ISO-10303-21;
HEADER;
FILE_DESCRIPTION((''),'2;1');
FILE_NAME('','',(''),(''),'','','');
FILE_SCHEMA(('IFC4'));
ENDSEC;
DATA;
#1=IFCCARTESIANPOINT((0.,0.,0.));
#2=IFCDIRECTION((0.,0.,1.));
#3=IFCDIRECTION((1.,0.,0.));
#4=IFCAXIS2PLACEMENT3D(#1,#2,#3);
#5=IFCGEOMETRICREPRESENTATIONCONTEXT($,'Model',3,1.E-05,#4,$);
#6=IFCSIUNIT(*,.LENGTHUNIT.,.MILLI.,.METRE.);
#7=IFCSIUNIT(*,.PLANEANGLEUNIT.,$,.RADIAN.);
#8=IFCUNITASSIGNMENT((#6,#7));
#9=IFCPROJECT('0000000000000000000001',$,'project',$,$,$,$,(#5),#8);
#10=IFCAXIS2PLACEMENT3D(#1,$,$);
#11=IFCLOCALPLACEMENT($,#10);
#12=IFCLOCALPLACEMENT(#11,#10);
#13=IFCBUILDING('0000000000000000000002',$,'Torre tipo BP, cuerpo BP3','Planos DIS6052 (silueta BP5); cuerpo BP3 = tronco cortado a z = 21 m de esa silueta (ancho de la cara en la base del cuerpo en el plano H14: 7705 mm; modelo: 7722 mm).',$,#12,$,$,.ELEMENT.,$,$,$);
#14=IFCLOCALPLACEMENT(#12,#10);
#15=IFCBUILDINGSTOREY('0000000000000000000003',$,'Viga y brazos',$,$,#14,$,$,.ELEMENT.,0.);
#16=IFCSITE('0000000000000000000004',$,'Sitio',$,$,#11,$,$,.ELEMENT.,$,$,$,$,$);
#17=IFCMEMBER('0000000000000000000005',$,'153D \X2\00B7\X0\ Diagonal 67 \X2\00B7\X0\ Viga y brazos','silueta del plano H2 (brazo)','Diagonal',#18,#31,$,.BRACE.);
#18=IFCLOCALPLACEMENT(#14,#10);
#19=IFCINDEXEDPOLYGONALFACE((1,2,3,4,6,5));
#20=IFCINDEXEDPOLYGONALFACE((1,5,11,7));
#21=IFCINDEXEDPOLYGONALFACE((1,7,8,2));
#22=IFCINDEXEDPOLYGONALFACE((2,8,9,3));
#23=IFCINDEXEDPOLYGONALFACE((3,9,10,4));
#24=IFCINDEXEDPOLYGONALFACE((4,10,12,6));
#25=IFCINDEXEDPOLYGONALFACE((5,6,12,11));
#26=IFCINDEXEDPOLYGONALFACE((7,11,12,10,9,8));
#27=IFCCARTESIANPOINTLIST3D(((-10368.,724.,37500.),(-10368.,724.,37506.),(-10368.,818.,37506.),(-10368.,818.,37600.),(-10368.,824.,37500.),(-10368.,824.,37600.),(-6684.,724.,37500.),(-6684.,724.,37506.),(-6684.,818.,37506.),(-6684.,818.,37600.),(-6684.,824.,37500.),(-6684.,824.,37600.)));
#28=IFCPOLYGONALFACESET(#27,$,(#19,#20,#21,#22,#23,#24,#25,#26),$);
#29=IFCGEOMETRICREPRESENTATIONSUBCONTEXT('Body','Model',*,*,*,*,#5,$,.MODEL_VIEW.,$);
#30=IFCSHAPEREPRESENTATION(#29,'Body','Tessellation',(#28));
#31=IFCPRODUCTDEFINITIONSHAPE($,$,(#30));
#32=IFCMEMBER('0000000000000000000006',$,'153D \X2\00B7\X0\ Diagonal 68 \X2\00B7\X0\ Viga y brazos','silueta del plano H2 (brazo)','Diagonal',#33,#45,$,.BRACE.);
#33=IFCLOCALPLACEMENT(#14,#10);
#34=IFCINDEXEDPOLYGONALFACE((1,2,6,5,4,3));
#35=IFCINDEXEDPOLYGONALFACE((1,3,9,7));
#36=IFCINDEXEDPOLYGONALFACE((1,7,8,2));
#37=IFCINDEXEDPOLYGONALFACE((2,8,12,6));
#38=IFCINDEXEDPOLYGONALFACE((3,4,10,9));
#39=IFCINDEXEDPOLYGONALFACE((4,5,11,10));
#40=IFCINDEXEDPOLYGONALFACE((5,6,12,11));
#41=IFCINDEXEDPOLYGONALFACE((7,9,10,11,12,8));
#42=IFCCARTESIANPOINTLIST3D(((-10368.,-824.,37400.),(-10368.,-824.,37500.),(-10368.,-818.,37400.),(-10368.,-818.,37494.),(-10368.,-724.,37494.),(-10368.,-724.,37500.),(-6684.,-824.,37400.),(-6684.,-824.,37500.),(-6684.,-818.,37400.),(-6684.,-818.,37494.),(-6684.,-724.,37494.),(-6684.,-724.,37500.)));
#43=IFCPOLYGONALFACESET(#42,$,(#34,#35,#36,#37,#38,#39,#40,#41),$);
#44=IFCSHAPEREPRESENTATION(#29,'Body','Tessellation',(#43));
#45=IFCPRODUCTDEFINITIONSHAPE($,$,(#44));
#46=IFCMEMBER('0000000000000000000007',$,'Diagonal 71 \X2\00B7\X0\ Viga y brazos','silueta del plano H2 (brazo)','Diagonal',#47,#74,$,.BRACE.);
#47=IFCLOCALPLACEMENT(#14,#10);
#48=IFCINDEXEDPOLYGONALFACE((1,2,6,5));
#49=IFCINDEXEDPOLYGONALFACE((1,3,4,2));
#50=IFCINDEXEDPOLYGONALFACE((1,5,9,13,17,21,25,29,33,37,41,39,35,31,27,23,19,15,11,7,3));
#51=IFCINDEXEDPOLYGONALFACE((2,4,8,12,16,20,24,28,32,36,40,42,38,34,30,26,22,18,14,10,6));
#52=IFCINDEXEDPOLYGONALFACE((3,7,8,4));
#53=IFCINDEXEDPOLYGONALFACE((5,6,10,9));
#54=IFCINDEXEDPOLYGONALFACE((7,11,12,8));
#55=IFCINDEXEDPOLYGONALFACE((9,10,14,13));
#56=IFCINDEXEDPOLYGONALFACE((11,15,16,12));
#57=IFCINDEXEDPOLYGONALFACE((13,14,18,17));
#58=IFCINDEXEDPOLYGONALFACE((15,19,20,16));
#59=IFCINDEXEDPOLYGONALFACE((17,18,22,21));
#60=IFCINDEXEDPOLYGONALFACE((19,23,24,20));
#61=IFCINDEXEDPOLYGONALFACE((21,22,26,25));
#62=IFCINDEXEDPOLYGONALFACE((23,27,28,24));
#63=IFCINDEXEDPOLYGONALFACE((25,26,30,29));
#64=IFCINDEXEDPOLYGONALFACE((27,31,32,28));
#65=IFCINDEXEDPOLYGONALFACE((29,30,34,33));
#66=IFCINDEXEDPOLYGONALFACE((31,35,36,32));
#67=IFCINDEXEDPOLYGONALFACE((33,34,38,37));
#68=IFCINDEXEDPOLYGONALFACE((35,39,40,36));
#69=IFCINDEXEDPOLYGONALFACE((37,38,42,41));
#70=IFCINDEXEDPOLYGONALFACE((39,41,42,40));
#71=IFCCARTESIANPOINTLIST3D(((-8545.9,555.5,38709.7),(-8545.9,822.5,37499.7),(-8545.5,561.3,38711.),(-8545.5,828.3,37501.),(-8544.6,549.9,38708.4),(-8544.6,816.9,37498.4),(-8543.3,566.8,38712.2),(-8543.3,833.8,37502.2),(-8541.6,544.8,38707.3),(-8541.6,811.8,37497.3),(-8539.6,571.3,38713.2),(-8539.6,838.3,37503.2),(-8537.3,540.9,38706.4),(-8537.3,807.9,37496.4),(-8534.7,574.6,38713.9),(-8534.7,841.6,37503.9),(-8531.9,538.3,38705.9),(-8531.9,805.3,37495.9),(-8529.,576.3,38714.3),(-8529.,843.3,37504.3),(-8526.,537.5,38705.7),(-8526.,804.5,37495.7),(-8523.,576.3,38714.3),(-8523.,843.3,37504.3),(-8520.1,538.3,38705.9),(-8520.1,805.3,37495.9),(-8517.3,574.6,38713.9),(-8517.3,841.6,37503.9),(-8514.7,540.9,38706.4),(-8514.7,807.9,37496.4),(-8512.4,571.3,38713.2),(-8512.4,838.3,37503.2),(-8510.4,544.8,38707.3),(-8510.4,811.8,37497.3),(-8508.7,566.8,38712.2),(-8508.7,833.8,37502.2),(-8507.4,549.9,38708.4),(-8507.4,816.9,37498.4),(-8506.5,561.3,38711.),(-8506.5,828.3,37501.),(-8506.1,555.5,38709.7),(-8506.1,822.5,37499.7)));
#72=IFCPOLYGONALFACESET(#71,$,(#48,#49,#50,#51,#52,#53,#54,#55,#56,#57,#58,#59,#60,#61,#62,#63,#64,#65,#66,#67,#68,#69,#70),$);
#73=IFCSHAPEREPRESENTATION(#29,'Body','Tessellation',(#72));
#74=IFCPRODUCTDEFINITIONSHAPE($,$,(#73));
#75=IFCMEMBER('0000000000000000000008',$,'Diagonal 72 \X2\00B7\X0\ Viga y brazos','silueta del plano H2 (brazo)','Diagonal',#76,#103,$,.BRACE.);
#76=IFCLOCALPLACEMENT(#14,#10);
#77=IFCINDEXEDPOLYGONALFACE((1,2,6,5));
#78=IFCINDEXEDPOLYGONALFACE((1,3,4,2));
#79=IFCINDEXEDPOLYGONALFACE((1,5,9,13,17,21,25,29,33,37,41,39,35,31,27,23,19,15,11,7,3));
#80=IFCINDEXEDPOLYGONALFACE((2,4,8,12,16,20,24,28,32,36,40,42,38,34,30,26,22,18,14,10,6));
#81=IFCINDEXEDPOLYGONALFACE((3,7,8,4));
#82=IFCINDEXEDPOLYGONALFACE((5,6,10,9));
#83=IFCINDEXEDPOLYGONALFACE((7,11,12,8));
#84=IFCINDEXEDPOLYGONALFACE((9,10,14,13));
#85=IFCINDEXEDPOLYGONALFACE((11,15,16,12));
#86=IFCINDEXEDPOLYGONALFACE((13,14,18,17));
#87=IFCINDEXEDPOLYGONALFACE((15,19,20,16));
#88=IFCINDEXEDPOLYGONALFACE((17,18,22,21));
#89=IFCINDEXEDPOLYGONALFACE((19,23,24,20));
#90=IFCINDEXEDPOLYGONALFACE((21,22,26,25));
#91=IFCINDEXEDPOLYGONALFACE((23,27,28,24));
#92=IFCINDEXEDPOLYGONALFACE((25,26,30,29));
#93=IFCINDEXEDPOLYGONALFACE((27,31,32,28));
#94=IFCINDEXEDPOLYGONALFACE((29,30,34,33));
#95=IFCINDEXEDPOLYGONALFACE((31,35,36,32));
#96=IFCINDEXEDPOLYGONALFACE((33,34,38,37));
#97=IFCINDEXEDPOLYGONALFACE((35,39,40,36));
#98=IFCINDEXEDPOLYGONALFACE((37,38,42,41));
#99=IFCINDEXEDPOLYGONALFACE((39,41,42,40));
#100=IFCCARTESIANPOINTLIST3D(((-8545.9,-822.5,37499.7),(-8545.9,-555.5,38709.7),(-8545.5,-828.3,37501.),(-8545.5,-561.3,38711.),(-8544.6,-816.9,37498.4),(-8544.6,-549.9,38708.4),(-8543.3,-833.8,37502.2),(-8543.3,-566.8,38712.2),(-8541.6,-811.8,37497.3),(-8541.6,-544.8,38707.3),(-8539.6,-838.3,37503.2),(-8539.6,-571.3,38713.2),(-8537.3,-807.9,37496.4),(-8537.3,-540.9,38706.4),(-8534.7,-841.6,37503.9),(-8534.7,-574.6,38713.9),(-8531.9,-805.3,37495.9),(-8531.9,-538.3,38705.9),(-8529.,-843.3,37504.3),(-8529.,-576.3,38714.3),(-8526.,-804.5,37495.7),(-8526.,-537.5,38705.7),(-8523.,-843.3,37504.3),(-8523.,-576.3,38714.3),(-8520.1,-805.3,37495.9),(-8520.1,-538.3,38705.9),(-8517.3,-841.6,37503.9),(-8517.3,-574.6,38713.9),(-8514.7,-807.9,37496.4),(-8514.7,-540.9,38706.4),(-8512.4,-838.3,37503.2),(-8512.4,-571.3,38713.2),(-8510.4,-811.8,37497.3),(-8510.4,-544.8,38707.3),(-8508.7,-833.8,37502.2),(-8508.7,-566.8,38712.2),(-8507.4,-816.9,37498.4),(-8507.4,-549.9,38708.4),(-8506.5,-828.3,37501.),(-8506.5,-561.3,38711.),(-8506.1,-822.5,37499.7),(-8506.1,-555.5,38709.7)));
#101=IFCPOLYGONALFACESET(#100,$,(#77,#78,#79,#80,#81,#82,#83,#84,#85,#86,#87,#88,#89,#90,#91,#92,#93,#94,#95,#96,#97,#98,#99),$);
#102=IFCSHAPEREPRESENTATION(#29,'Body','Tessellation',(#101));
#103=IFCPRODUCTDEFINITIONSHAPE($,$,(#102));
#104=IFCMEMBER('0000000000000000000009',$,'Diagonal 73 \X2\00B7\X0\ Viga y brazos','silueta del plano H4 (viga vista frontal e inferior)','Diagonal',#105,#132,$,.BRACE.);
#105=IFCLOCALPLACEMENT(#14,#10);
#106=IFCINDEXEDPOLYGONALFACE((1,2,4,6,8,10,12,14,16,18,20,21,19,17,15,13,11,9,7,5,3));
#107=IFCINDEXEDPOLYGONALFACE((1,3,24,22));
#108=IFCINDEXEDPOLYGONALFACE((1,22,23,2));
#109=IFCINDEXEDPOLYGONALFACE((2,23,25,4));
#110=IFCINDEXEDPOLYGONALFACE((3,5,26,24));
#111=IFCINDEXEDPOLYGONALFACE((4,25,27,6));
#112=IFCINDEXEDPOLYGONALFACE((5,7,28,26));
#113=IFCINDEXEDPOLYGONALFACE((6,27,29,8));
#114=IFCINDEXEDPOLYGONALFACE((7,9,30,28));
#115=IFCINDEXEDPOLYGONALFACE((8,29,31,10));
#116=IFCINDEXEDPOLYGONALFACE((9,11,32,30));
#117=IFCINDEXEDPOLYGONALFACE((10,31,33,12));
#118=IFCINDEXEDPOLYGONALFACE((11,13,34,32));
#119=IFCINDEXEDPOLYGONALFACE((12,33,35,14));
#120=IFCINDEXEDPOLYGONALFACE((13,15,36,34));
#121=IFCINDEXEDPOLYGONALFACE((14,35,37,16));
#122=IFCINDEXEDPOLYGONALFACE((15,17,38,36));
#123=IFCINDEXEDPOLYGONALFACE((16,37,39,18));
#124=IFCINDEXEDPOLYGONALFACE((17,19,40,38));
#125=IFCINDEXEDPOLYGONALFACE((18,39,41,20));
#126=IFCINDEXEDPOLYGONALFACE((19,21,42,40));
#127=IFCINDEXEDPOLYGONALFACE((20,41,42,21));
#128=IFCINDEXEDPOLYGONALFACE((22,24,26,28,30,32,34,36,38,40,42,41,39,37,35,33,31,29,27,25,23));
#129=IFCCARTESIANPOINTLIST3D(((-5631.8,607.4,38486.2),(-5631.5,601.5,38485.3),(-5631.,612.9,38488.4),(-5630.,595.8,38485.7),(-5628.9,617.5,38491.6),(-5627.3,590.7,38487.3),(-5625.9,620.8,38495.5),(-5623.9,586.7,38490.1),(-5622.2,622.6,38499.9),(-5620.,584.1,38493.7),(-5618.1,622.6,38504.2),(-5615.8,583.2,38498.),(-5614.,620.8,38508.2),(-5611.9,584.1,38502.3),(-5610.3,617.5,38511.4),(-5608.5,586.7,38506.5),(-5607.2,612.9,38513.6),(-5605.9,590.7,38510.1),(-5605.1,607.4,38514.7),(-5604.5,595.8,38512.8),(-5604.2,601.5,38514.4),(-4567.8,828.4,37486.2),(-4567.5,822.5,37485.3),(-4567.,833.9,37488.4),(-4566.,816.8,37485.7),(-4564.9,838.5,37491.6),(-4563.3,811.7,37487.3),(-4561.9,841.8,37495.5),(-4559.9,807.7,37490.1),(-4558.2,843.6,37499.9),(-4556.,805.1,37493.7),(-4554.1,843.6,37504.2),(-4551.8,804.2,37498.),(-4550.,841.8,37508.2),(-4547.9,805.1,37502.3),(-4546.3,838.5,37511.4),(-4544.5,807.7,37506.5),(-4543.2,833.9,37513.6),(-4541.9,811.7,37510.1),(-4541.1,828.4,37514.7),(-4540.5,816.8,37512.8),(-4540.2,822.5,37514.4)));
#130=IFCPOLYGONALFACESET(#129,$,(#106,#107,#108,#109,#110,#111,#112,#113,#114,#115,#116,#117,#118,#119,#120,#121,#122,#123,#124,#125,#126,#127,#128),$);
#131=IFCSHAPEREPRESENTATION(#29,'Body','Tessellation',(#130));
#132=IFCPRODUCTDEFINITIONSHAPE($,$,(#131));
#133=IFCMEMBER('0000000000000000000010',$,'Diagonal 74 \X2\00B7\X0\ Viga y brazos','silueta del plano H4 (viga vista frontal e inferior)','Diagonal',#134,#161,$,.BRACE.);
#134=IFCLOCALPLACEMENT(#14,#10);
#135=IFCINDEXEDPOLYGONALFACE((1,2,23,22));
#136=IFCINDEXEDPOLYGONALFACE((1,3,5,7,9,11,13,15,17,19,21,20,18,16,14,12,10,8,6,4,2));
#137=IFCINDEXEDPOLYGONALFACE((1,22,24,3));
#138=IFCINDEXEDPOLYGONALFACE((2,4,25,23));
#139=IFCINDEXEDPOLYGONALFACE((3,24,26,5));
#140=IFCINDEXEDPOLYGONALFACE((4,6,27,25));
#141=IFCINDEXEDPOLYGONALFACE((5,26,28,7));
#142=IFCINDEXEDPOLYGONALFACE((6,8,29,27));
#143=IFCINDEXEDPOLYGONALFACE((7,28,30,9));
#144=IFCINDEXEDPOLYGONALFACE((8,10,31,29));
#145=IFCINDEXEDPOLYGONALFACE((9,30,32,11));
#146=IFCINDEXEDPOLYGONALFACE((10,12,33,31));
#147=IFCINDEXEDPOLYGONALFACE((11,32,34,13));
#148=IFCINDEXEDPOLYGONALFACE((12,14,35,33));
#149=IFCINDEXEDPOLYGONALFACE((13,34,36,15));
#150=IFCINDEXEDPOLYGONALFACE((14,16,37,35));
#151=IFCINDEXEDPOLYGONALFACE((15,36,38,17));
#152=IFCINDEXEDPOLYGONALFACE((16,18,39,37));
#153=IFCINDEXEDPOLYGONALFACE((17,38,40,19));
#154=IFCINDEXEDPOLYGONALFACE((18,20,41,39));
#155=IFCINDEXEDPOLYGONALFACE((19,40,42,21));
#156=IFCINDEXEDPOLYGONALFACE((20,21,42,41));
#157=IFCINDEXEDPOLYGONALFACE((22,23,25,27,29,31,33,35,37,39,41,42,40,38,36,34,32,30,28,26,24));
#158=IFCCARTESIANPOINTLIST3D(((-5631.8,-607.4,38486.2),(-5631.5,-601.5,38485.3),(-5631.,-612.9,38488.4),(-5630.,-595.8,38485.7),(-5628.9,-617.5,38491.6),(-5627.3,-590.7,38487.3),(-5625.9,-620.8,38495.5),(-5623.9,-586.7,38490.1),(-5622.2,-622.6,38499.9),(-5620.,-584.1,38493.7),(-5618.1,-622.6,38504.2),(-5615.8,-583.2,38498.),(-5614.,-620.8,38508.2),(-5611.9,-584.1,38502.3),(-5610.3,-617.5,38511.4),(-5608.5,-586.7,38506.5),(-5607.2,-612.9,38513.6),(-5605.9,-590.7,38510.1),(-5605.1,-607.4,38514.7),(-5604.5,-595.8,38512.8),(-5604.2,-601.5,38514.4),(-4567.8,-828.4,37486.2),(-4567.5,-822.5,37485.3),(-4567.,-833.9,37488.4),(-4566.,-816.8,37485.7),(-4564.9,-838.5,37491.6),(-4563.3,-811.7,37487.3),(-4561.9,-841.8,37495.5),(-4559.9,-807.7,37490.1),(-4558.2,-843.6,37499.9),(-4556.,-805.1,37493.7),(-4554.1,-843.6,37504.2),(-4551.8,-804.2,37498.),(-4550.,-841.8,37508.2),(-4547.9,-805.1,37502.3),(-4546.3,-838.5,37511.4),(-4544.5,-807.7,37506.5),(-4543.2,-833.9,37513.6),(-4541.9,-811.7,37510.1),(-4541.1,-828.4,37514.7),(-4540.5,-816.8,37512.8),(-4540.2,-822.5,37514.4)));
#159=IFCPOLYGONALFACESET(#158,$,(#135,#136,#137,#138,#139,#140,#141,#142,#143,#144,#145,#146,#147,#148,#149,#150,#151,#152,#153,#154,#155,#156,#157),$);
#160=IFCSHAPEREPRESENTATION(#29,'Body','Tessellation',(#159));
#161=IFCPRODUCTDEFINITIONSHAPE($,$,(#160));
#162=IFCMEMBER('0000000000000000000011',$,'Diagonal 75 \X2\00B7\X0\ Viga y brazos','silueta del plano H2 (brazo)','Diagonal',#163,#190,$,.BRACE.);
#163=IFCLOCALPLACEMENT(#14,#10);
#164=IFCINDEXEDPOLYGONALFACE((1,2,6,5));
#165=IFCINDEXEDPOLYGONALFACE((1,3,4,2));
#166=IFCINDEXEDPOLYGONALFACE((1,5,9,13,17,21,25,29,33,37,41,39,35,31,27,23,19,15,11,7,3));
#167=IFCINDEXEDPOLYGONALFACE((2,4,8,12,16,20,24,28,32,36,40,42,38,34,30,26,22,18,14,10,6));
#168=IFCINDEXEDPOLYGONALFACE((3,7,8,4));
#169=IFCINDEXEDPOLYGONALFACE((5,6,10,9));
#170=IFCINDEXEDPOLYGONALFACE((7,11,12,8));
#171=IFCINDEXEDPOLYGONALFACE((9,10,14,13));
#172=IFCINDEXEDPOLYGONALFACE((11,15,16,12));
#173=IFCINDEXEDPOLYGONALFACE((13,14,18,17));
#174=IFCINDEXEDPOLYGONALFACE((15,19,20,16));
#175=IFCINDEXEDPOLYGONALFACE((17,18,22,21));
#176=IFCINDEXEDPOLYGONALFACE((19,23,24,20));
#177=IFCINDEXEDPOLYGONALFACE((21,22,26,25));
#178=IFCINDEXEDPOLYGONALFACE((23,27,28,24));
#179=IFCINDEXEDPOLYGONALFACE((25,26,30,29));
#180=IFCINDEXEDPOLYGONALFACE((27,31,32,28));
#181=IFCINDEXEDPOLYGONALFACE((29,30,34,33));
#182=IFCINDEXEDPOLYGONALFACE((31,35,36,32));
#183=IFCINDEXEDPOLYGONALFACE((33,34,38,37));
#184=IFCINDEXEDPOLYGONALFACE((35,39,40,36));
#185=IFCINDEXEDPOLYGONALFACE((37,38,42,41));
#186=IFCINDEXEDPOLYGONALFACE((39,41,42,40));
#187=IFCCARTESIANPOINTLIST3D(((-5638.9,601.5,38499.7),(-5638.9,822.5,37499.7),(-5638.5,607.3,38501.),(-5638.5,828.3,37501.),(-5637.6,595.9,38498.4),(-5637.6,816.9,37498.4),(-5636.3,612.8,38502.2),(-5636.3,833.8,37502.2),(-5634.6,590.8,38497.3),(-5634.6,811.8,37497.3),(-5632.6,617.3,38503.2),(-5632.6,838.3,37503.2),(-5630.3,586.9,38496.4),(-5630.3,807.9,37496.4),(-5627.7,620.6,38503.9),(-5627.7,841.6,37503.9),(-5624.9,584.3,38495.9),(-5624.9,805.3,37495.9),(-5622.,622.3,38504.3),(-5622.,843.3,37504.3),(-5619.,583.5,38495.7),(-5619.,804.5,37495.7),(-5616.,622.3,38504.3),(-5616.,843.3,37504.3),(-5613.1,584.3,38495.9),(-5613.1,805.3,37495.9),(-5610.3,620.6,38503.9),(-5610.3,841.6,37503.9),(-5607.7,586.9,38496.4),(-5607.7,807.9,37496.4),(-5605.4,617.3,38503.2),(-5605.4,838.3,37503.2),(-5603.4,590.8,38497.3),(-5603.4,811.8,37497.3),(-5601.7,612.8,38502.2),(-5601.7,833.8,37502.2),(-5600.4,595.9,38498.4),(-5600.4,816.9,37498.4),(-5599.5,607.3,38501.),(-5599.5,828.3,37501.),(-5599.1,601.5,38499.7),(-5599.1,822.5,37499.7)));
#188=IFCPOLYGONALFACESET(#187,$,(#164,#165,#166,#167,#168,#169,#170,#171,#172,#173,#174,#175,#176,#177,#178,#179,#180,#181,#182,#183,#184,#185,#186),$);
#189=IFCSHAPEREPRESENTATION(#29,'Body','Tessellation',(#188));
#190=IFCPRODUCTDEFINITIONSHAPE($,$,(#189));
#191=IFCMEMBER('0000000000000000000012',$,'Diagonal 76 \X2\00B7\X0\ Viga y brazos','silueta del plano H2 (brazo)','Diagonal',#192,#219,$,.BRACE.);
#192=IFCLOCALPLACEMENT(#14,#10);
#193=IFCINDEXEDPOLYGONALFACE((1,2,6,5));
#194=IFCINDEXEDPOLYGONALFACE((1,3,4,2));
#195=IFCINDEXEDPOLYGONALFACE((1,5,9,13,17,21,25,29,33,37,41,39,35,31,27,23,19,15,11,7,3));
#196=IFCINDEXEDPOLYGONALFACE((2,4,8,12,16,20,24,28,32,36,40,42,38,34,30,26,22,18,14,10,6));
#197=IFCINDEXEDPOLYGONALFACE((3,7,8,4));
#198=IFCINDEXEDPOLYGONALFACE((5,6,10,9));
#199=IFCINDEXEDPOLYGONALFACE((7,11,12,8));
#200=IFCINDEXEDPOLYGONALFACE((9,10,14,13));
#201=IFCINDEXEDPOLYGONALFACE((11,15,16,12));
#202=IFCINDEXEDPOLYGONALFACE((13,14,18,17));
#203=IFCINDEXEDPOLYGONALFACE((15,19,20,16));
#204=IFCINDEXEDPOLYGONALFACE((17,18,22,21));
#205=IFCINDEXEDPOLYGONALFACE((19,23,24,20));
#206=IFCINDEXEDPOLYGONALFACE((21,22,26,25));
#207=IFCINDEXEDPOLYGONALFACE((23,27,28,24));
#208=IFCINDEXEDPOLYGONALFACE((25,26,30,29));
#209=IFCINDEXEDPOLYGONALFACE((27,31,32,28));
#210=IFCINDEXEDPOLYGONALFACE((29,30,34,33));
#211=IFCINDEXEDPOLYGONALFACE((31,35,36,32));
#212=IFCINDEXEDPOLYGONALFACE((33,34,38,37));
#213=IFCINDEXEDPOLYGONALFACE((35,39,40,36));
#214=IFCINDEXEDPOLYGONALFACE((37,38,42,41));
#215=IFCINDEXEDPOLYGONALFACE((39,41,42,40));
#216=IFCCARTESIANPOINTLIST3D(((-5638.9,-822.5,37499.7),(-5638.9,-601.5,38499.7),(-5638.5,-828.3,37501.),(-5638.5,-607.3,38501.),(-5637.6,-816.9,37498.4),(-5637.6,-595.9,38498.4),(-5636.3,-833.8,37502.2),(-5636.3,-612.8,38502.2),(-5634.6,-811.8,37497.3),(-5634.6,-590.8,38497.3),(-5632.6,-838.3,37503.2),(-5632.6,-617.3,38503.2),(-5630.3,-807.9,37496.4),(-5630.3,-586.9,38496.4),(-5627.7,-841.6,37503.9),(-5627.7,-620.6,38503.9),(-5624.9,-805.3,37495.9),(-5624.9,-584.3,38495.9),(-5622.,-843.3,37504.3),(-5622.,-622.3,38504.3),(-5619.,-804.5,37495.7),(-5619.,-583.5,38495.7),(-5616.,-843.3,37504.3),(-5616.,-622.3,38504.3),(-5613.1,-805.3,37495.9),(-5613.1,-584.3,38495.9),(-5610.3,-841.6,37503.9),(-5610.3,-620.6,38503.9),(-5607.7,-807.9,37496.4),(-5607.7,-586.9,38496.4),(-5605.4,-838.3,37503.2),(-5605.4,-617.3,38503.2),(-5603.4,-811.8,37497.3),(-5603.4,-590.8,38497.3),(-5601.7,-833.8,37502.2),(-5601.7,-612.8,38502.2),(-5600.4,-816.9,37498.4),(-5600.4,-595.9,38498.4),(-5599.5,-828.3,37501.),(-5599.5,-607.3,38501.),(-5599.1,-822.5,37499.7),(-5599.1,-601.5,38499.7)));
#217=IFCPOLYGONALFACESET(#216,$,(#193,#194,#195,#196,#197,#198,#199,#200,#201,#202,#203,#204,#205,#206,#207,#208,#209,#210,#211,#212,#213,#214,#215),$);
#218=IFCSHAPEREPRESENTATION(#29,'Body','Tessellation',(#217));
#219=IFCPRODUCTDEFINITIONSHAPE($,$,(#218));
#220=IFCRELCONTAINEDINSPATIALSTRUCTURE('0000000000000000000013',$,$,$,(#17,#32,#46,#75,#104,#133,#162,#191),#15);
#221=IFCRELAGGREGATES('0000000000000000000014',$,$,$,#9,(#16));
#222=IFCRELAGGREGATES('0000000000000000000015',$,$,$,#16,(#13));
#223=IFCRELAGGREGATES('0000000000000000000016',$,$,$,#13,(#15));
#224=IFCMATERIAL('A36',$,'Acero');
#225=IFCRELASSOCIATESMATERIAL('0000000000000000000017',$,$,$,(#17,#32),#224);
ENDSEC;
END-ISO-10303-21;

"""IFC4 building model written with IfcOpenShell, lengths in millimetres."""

from ifc_helpers import new_model, si_unit, frame, frame_2d, origin, origin_with_axes, place, context, subcontext, project, spatial, circle, l_section, extrude, material, element, save


model = new_model("IFC4")

# Units and contexts
model_context = context("Model", 3, precision=1e-05, world=origin_with_axes())
body_context = subcontext(model_context, "Body", "Model", "MODEL_VIEW")
ifc_project = project(units=[si_unit("LENGTHUNIT", "METRE", prefix="MILLI"), si_unit("PLANEANGLEUNIT", "RADIAN")], contexts=[model_context])

# Site, building, storey
site_placement = place(None, origin())
site = spatial("IfcSite", under=ifc_project, at=site_placement, Name="Sitio", CompositionType="ELEMENT")
building_placement = place(site_placement, origin())
building = spatial("IfcBuilding", under=site, at=building_placement, Name="Torre tipo BP, cuerpo BP3", Description="Planos DIS6052 (silueta BP5); cuerpo BP3 = tronco cortado a z = 21 m de esa silueta (ancho de la cara en la base del cuerpo en el plano H14: 7705 mm; modelo: 7722 mm).", CompositionType="ELEMENT")
storey_placement = place(building_placement, origin())
storey = spatial("IfcBuildingStorey", under=building, at=storey_placement, Name="Viga y brazos", CompositionType="ELEMENT", Elevation=0.0)

# Members
ifc_material_1 = material(Name="A36", Category="Acero")
for number, where, z_axis, x_axis, name in (
    (1, (-6684.0, 824.0, 37500.0), (-1.0, 0.0, 0.0), (0.0, -1.0, 0.0), "153D · Diagonal 67 · Viga y brazos"),
    (2, (-6684.0, -824.0, 37500.0), (-1.0, 0.0, 0.0), (0.0, 1.0, 0.0), "153D · Diagonal 68 · Viga y brazos"),
):
    element("IfcMember", number, at=place(storey_placement, frame(where, z_axis=z_axis, x_axis=x_axis)), inside=storey, material=ifc_material_1, Name=name, Description="silueta del plano H2 (brazo)", ObjectType="Diagonal", PredefinedType="BRACE", context=body_context, shape_type="SweptSolid", body=[
        extrude(l_section(Depth=100.0, Width=100.0, Thickness=6.0, at=frame_2d((50.0, 50.0))), None, (0.0, 0.0, 1.0), 3684.0),
    ])
for number, where, z_axis, x_axis, name in (
    (3, (-8526.0, 557.0, 38710.0), (0.0, 0.215478, -0.976509), (0.0, -0.976509, -0.215478), "Diagonal 71 · Viga y brazos"),
    (4, (-8526.0, -557.0, 38710.0), (0.0, -0.215478, -0.976509), (0.0, 0.976509, -0.215478), "Diagonal 72 · Viga y brazos"),
):
    element("IfcMember", number, at=place(storey_placement, frame(where, z_axis=z_axis, x_axis=x_axis)), inside=storey, Name=name, Description="silueta del plano H2 (brazo)", ObjectType="Diagonal", PredefinedType="BRACE", context=body_context, shape_type="SweptSolid", body=[
        extrude(circle(Radius=20.0), None, (0.0, 0.0, 1.0), 1239.1),
    ])
for number, where, z_axis, x_axis, name in (
    (5, (-4554.0, 824.0, 37500.0), (-0.720477, -0.149648, 0.67714), (0.109046, -0.988739, -0.102487), "Diagonal 73 · Viga y brazos"),
    (6, (-4554.0, -824.0, 37500.0), (-0.720477, 0.149648, 0.67714), (0.109046, 0.988739, -0.102487), "Diagonal 74 · Viga y brazos"),
):
    element("IfcMember", number, at=place(storey_placement, frame(where, z_axis=z_axis, x_axis=x_axis)), inside=storey, Name=name, Description="silueta del plano H4 (viga vista frontal e inferior)", ObjectType="Diagonal", PredefinedType="BRACE", context=body_context, shape_type="SweptSolid", body=[
        extrude(circle(Radius=20.0), None, (0.0, 0.0, 1.0), 1476.8),
    ])
for number, where, z_axis, x_axis, name in (
    (7, (-5619.0, 824.0, 37500.0), (0.0, -0.215793, 0.976439), (0.0, -0.976439, -0.215793), "Diagonal 75 · Viga y brazos"),
    (8, (-5619.0, -824.0, 37500.0), (0.0, 0.215793, 0.976439), (0.0, 0.976439, -0.215793), "Diagonal 76 · Viga y brazos"),
):
    element("IfcMember", number, at=place(storey_placement, frame(where, z_axis=z_axis, x_axis=x_axis)), inside=storey, Name=name, Description="silueta del plano H2 (brazo)", ObjectType="Diagonal", PredefinedType="BRACE", context=body_context, shape_type="SweptSolid", body=[
        extrude(circle(Radius=20.0), None, (0.0, 0.0, 1.0), 1024.1),
    ])

save(model, "model.ifc")
